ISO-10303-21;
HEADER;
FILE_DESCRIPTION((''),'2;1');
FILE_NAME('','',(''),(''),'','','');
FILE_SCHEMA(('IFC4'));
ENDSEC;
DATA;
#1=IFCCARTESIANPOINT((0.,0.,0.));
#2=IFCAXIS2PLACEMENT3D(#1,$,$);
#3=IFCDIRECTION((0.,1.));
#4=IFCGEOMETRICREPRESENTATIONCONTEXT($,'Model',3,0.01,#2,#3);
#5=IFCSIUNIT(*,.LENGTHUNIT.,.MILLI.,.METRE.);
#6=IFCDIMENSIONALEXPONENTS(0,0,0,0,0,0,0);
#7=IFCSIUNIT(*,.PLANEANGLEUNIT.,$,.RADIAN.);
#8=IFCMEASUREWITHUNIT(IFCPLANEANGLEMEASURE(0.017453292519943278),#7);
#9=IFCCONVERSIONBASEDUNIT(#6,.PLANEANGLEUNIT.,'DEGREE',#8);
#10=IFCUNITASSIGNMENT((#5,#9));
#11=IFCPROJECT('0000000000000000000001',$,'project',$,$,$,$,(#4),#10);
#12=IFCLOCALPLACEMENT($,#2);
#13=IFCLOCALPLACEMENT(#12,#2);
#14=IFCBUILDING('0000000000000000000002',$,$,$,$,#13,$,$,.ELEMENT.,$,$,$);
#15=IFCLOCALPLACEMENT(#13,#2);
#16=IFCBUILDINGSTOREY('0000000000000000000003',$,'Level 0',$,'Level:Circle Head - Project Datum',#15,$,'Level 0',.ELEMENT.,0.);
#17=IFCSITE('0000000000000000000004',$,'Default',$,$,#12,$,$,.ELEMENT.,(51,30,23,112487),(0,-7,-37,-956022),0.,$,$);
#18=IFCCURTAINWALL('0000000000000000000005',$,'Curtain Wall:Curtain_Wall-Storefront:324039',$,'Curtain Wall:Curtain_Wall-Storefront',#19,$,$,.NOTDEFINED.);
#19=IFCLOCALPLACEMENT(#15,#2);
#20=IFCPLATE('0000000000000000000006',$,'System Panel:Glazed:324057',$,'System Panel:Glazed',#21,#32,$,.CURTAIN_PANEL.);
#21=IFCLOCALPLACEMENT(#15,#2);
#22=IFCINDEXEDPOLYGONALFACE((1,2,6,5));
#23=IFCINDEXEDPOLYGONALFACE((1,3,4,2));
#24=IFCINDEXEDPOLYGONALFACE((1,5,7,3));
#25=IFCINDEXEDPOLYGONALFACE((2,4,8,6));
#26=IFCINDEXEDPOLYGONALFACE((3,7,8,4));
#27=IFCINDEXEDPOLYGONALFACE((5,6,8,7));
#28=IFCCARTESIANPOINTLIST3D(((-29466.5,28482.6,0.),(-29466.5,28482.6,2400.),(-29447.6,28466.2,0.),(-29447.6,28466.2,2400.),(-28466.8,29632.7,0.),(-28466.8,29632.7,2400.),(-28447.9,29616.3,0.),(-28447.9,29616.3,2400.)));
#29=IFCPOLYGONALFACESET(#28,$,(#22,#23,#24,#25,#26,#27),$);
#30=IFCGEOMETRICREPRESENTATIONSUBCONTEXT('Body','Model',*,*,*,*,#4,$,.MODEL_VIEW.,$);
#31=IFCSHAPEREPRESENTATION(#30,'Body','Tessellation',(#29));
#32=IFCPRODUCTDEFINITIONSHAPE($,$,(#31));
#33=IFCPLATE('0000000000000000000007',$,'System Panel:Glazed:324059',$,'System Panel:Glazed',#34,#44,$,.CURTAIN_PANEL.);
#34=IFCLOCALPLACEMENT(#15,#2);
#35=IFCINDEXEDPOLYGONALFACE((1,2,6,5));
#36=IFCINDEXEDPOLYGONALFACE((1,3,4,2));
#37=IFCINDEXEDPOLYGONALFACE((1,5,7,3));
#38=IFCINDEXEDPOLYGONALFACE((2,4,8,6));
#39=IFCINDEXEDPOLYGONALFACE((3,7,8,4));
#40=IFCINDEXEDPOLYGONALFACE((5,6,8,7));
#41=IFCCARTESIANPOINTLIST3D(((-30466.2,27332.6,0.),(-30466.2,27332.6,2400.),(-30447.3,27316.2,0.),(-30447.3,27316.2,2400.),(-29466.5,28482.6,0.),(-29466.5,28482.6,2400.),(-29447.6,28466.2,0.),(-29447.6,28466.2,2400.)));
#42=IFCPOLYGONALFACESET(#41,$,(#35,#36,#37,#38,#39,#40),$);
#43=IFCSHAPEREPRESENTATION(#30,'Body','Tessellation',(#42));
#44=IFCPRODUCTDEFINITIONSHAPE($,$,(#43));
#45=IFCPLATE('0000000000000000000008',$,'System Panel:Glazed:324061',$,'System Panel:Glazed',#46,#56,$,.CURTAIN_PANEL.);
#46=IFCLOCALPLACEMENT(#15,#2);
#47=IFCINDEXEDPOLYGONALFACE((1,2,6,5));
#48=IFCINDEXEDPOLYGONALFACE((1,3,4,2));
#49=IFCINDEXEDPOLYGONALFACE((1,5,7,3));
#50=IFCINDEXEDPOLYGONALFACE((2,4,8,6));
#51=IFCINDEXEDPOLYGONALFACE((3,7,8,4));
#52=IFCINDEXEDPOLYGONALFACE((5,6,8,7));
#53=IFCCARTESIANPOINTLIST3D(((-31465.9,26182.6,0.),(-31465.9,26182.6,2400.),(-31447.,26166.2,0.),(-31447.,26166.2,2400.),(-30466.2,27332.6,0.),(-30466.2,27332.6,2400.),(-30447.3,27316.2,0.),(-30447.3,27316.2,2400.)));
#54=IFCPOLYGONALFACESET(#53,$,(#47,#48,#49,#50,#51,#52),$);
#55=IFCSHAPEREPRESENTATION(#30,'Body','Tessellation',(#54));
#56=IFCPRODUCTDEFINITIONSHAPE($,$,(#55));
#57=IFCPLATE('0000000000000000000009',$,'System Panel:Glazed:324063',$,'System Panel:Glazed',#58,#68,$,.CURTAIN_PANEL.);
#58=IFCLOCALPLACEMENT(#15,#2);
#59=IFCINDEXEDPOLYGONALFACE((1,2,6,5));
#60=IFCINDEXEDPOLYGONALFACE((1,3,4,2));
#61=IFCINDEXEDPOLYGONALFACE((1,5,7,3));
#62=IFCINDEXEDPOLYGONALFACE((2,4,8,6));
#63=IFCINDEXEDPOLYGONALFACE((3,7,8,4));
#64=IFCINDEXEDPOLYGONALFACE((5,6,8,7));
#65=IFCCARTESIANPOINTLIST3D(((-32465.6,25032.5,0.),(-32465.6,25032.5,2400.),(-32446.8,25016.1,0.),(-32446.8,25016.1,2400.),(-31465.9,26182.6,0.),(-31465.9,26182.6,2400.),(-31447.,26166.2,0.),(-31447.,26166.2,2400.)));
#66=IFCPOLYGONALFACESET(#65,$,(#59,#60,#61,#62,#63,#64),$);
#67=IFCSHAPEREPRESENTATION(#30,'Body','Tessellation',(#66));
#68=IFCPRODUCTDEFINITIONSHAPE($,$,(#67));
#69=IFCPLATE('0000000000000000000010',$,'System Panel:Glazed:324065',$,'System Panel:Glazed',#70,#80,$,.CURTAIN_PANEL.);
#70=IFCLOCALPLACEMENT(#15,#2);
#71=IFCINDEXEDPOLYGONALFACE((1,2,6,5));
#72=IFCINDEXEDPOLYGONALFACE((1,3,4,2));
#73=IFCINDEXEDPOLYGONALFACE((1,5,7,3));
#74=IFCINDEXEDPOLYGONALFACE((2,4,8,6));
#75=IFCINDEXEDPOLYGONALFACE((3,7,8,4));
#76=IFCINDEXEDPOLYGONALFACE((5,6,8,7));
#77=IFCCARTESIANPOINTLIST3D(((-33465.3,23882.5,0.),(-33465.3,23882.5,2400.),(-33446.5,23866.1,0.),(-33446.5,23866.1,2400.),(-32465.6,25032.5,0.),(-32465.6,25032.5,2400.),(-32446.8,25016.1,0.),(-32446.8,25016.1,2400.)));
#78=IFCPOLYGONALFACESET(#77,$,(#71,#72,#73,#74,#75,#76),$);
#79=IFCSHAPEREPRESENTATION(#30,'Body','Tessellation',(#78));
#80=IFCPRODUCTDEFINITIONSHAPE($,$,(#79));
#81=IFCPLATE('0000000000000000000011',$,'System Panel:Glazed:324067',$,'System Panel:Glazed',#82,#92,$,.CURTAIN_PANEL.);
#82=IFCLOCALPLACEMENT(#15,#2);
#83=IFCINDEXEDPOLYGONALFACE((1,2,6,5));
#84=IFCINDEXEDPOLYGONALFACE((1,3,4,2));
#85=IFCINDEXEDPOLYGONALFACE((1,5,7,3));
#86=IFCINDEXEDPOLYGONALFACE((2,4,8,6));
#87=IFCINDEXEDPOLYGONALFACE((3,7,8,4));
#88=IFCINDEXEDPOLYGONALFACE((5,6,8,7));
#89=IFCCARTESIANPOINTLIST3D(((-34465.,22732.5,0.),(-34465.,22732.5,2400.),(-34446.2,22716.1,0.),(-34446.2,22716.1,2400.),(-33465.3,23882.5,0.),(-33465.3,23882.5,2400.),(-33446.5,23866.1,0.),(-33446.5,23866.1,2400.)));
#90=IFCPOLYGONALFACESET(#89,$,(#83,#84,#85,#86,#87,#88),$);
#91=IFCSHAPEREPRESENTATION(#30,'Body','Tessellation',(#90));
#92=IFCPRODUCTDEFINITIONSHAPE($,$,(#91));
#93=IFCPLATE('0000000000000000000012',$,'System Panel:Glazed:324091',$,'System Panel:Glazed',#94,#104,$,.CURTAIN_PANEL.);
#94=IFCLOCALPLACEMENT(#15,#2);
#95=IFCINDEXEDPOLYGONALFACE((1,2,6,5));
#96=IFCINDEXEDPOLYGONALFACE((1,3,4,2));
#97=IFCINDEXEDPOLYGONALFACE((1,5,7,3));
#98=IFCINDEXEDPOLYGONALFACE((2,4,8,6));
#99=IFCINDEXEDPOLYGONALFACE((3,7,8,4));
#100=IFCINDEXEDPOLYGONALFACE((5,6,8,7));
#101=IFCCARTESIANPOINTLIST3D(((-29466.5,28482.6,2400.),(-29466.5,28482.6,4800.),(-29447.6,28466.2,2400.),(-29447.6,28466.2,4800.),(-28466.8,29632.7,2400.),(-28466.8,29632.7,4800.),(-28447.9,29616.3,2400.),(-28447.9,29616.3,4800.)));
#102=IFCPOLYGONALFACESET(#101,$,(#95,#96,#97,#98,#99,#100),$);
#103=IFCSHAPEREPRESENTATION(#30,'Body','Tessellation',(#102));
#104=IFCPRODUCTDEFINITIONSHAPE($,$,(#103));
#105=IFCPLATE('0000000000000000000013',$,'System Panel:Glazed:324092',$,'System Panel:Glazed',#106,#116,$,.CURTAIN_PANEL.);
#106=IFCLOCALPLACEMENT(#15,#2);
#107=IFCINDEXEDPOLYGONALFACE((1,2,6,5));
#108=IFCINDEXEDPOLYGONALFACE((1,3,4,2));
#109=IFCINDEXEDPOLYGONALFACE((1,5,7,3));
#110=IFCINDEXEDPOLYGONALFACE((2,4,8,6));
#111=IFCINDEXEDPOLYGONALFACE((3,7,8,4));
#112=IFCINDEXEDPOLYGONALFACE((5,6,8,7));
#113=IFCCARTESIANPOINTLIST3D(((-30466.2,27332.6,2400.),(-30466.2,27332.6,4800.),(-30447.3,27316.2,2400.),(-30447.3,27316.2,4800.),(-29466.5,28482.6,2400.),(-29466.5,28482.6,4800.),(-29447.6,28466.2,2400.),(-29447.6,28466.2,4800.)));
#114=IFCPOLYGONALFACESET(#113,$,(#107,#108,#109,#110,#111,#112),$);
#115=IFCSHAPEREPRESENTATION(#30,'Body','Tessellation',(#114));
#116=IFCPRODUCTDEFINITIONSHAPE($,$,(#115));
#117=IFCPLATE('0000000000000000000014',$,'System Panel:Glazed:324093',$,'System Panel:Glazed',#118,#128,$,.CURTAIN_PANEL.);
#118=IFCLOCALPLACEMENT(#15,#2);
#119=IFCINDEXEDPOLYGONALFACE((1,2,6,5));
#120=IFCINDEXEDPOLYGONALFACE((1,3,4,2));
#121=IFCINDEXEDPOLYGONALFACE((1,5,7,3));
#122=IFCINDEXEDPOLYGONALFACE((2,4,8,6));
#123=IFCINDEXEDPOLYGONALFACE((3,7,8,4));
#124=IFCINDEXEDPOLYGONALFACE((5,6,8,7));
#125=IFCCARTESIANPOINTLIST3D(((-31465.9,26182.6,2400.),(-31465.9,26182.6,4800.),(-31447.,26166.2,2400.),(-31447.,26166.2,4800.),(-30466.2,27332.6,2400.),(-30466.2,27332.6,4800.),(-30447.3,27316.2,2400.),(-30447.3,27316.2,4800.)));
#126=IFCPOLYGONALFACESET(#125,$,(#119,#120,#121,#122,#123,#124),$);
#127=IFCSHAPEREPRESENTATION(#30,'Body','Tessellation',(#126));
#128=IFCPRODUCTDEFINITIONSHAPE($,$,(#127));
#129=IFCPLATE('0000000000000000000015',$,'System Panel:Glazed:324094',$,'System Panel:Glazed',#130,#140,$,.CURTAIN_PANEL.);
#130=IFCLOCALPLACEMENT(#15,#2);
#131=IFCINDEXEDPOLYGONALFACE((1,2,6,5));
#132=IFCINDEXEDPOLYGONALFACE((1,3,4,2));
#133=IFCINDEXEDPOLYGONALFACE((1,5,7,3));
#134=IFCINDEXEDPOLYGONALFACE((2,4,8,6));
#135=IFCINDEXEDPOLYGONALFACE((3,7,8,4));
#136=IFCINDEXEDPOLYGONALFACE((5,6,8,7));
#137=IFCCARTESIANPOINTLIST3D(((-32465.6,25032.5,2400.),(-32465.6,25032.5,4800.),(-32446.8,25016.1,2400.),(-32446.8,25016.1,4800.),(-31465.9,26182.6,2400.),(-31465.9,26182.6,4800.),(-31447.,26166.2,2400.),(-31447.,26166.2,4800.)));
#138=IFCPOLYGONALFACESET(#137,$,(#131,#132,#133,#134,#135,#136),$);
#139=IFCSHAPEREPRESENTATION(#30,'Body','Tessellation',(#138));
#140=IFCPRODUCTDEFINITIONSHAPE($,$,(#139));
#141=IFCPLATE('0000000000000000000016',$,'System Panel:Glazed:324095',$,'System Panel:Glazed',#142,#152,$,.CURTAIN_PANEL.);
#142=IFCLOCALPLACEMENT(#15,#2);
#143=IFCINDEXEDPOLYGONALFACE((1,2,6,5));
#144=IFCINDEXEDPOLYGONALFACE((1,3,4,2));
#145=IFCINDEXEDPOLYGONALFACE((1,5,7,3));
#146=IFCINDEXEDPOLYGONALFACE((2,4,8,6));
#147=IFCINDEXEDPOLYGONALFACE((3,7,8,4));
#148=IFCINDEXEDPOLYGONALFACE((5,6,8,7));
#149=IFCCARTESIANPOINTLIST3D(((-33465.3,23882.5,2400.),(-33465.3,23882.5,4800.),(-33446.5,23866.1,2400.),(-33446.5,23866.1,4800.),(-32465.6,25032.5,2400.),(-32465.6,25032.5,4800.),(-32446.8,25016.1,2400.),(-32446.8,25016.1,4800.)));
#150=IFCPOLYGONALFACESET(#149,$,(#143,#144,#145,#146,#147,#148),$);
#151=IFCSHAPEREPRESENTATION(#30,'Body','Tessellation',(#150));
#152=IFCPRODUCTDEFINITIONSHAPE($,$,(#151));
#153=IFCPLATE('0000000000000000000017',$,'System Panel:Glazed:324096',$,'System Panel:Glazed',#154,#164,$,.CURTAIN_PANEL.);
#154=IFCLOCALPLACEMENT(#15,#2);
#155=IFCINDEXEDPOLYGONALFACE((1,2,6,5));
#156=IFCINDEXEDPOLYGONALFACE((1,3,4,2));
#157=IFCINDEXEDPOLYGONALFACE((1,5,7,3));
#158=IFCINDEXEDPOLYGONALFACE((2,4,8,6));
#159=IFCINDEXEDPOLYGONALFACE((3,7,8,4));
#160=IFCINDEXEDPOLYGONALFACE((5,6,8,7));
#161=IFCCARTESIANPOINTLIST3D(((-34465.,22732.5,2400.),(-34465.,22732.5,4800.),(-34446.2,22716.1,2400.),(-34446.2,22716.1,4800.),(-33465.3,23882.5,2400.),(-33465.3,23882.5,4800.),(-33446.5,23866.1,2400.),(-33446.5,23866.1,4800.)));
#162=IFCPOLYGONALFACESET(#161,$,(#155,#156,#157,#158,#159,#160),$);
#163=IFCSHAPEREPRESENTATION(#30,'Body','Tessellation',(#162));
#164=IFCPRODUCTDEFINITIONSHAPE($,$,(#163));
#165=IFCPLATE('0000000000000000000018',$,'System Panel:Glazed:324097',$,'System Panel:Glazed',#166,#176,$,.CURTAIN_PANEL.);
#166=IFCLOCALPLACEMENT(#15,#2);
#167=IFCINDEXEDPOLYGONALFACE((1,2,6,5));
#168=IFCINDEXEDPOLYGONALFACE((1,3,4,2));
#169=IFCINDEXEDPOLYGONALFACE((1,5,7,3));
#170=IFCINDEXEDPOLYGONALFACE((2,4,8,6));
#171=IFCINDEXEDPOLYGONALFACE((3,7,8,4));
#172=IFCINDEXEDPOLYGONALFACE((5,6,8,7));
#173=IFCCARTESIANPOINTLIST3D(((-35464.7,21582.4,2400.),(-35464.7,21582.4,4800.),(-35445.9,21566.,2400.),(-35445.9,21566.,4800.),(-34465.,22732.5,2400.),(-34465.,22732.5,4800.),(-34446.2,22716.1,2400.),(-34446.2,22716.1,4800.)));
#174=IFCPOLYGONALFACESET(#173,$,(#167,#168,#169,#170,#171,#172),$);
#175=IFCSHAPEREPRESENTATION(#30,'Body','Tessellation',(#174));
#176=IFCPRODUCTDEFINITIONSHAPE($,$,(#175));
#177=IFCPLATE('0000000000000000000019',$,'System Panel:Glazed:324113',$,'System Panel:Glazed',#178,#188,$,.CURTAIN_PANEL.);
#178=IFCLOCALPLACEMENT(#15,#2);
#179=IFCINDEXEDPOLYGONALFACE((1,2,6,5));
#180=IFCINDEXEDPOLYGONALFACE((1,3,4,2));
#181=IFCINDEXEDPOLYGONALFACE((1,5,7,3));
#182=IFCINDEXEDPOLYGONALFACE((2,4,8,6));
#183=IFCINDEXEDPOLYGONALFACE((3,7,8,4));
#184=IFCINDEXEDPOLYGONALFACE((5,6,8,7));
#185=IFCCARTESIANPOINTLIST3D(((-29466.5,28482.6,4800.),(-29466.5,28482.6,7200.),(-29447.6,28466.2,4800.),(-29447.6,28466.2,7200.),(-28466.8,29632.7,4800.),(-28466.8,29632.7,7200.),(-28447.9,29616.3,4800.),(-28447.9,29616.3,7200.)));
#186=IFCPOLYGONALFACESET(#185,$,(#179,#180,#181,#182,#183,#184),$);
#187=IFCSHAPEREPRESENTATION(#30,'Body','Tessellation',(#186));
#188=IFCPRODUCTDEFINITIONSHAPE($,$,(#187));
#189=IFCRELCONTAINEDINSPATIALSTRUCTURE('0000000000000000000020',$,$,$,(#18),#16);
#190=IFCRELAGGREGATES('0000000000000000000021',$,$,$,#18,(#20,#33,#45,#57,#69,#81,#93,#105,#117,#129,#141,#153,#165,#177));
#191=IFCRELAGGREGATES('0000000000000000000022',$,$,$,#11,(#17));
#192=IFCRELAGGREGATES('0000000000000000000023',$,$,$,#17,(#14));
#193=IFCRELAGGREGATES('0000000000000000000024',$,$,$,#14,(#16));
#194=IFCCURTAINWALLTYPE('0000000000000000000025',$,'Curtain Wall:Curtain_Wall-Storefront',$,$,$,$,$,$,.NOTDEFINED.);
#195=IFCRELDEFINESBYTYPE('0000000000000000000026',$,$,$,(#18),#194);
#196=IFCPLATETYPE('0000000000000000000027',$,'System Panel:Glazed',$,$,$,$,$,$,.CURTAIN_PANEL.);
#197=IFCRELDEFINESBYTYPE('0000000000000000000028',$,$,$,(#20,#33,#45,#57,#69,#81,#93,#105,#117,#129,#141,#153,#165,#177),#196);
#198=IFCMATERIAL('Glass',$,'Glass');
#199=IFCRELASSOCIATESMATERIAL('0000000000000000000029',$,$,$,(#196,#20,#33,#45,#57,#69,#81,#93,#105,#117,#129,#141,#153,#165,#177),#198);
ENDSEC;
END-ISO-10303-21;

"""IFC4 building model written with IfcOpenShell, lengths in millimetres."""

from ifc_helpers import new_model, entity, si_unit, converted_unit, direction, frame, origin, place, context, subcontext, project, spatial, indexed_curve, outline, extrude, source, transform, mapped, material, type_object, type_shapes, element, aggregate, save


model = new_model("IFC4")

# Units and contexts
model_context = context("Model", 3, precision=0.01, world=origin(), true_north=direction((0.0, 1.0)))
body_context = subcontext(model_context, "Body", "Model", "MODEL_VIEW")
ifc_project = project(units=[si_unit("LENGTHUNIT", "METRE", prefix="MILLI"), converted_unit("PLANEANGLEUNIT", "DEGREE", entity("IfcPlaneAngleMeasure", 0.017453292519943278), si_unit("PLANEANGLEUNIT", "RADIAN"), dimensions=[0, 0, 0, 0, 0, 0, 0])], contexts=[model_context])

# Site, building, storey
site_placement = place(None, origin())
site = spatial("IfcSite", under=ifc_project, at=site_placement, Name="Default", CompositionType="ELEMENT", RefLatitude=(51, 30, 23, 112487), RefLongitude=(0, -7, -37, -956022), RefElevation=0.0)
building_placement = place(site_placement, origin())
building = spatial("IfcBuilding", under=site, at=building_placement, CompositionType="ELEMENT")
storey_placement = place(building_placement, origin())
storey = spatial("IfcBuildingStorey", under=building, at=storey_placement, Name="Level 0", ObjectType="Level:Circle Head - Project Datum", LongName="Level 0", CompositionType="ELEMENT", Elevation=0.0)

# Curtain wall, plates
curtain_wall_type = type_object("IfcCurtainWallType", Name="Curtain Wall:Curtain_Wall-Storefront", PredefinedType="NOTDEFINED")
curtain_wall_placement = place(storey_placement, origin())
curtain_wall = element("IfcCurtainWall", 1, at=curtain_wall_placement, inside=storey, type_object=curtain_wall_type, Name="Curtain Wall:Curtain_Wall-Storefront:324039", ObjectType="Curtain Wall:Curtain_Wall-Storefront", PredefinedType="NOTDEFINED")
ifc_material = material(Name="Glass", Category="Glass")
plate_type_1 = type_object("IfcPlateType", Name="System Panel:Glazed", PredefinedType="CURTAIN_PANEL", material=ifc_material)
shared_shape_1 = source(origin(), body_context, "Body", "SweptSolid", [
    extrude(outline(indexed_curve([(-12.5, -761.9), (12.5, -761.9), (12.5, 761.9), (-12.5, 761.9), (-12.5, -761.9)], self_intersect=False)), frame((0.0, 37.0, 0.0), z_axis=(0.0, 0.0, 1.0), x_axis=(0.0, 1.0, 0.0)), (0.0, 0.0, 1.0), 2400.0),
])
type_shapes(plate_type_1, [shared_shape_1])
plate_1_placement = place(curtain_wall_placement, frame((-28985.1, 29073.7, 0.0), z_axis=(0.0, 0.0, 1.0), x_axis=(-0.656059, -0.75471, 0.0)))
plate_1 = element("IfcPlate", 2, at=plate_1_placement, type_object=plate_type_1, material=ifc_material, Name="System Panel:Glazed:324057", ObjectType="System Panel:Glazed", PredefinedType="CURTAIN_PANEL", context=body_context, shape_type="MappedRepresentation", body=[
    mapped(shared_shape_1, transform((0.0, 0.0, 0.0), scale=1.0)),
])
plate_2_placement = place(curtain_wall_placement, frame((-29984.8, 27923.7, 0.0), z_axis=(0.0, 0.0, 1.0), x_axis=(-0.656059, -0.75471, 0.0)))
plate_2 = element("IfcPlate", 3, at=plate_2_placement, type_object=plate_type_1, material=ifc_material, Name="System Panel:Glazed:324059", ObjectType="System Panel:Glazed", PredefinedType="CURTAIN_PANEL", context=body_context, shape_type="MappedRepresentation", body=[
    mapped(shared_shape_1, transform((0.0, 0.0, 0.0), scale=1.0)),
])
plate_3_placement = place(curtain_wall_placement, frame((-30984.5, 26773.7, 0.0), z_axis=(0.0, 0.0, 1.0), x_axis=(-0.656059, -0.75471, 0.0)))
plate_3 = element("IfcPlate", 4, at=plate_3_placement, type_object=plate_type_1, material=ifc_material, Name="System Panel:Glazed:324061", ObjectType="System Panel:Glazed", PredefinedType="CURTAIN_PANEL", context=body_context, shape_type="MappedRepresentation", body=[
    mapped(shared_shape_1, transform((0.0, 0.0, 0.0), scale=1.0)),
])
plate_4_placement = place(curtain_wall_placement, frame((-31984.3, 25623.6, 0.0), z_axis=(0.0, 0.0, 1.0), x_axis=(-0.656059, -0.75471, 0.0)))
plate_4 = element("IfcPlate", 5, at=plate_4_placement, type_object=plate_type_1, material=ifc_material, Name="System Panel:Glazed:324063", ObjectType="System Panel:Glazed", PredefinedType="CURTAIN_PANEL", context=body_context, shape_type="MappedRepresentation", body=[
    mapped(shared_shape_1, transform((0.0, 0.0, 0.0), scale=1.0)),
])
plate_5_placement = place(curtain_wall_placement, frame((-32984.0, 24473.6, 0.0), z_axis=(0.0, 0.0, 1.0), x_axis=(-0.656059, -0.75471, 0.0)))
plate_5 = element("IfcPlate", 6, at=plate_5_placement, type_object=plate_type_1, material=ifc_material, Name="System Panel:Glazed:324065", ObjectType="System Panel:Glazed", PredefinedType="CURTAIN_PANEL", context=body_context, shape_type="MappedRepresentation", body=[
    mapped(shared_shape_1, transform((0.0, 0.0, 0.0), scale=1.0)),
])
plate_6_placement = place(curtain_wall_placement, frame((-33983.7, 23323.6, 0.0), z_axis=(0.0, 0.0, 1.0), x_axis=(-0.656059, -0.75471, 0.0)))
plate_6 = element("IfcPlate", 7, at=plate_6_placement, type_object=plate_type_1, material=ifc_material, Name="System Panel:Glazed:324067", ObjectType="System Panel:Glazed", PredefinedType="CURTAIN_PANEL", context=body_context, shape_type="MappedRepresentation", body=[
    mapped(shared_shape_1, transform((0.0, 0.0, 0.0), scale=1.0)),
])
plate_7_placement = place(curtain_wall_placement, frame((-28985.1, 29073.7, 2400.0), z_axis=(0.0, 0.0, 1.0), x_axis=(-0.656059, -0.75471, 0.0)))
plate_7 = element("IfcPlate", 8, at=plate_7_placement, type_object=plate_type_1, material=ifc_material, Name="System Panel:Glazed:324091", ObjectType="System Panel:Glazed", PredefinedType="CURTAIN_PANEL", context=body_context, shape_type="MappedRepresentation", body=[
    mapped(shared_shape_1, transform((0.0, 0.0, 0.0), scale=1.0)),
])
plate_8_placement = place(curtain_wall_placement, frame((-29984.8, 27923.7, 2400.0), z_axis=(0.0, 0.0, 1.0), x_axis=(-0.656059, -0.75471, 0.0)))
plate_8 = element("IfcPlate", 9, at=plate_8_placement, type_object=plate_type_1, material=ifc_material, Name="System Panel:Glazed:324092", ObjectType="System Panel:Glazed", PredefinedType="CURTAIN_PANEL", context=body_context, shape_type="MappedRepresentation", body=[
    mapped(shared_shape_1, transform((0.0, 0.0, 0.0), scale=1.0)),
])
plate_9_placement = place(curtain_wall_placement, frame((-30984.5, 26773.7, 2400.0), z_axis=(0.0, 0.0, 1.0), x_axis=(-0.656059, -0.75471, 0.0)))
plate_9 = element("IfcPlate", 10, at=plate_9_placement, type_object=plate_type_1, material=ifc_material, Name="System Panel:Glazed:324093", ObjectType="System Panel:Glazed", PredefinedType="CURTAIN_PANEL", context=body_context, shape_type="MappedRepresentation", body=[
    mapped(shared_shape_1, transform((0.0, 0.0, 0.0), scale=1.0)),
])
plate_10_placement = place(curtain_wall_placement, frame((-31984.3, 25623.6, 2400.0), z_axis=(0.0, 0.0, 1.0), x_axis=(-0.656059, -0.75471, 0.0)))
plate_10 = element("IfcPlate", 11, at=plate_10_placement, type_object=plate_type_1, material=ifc_material, Name="System Panel:Glazed:324094", ObjectType="System Panel:Glazed", PredefinedType="CURTAIN_PANEL", context=body_context, shape_type="MappedRepresentation", body=[
    mapped(shared_shape_1, transform((0.0, 0.0, 0.0), scale=1.0)),
])
plate_11_placement = place(curtain_wall_placement, frame((-32984.0, 24473.6, 2400.0), z_axis=(0.0, 0.0, 1.0), x_axis=(-0.656059, -0.75471, 0.0)))
plate_11 = element("IfcPlate", 12, at=plate_11_placement, type_object=plate_type_1, material=ifc_material, Name="System Panel:Glazed:324095", ObjectType="System Panel:Glazed", PredefinedType="CURTAIN_PANEL", context=body_context, shape_type="MappedRepresentation", body=[
    mapped(shared_shape_1, transform((0.0, 0.0, 0.0), scale=1.0)),
])
plate_12_placement = place(curtain_wall_placement, frame((-33983.7, 23323.6, 2400.0), z_axis=(0.0, 0.0, 1.0), x_axis=(-0.656059, -0.75471, 0.0)))
plate_12 = element("IfcPlate", 13, at=plate_12_placement, type_object=plate_type_1, material=ifc_material, Name="System Panel:Glazed:324096", ObjectType="System Panel:Glazed", PredefinedType="CURTAIN_PANEL", context=body_context, shape_type="MappedRepresentation", body=[
    mapped(shared_shape_1, transform((0.0, 0.0, 0.0), scale=1.0)),
])
plate_13_placement = place(curtain_wall_placement, frame((-34983.4, 22173.5, 2400.0), z_axis=(0.0, 0.0, 1.0), x_axis=(-0.656059, -0.75471, 0.0)))
plate_13 = element("IfcPlate", 14, at=plate_13_placement, type_object=plate_type_1, material=ifc_material, Name="System Panel:Glazed:324097", ObjectType="System Panel:Glazed", PredefinedType="CURTAIN_PANEL", context=body_context, shape_type="MappedRepresentation", body=[
    mapped(shared_shape_1, transform((0.0, 0.0, 0.0), scale=1.0)),
])
plate_14_placement = place(curtain_wall_placement, frame((-28985.1, 29073.7, 4800.0), z_axis=(0.0, 0.0, 1.0), x_axis=(-0.656059, -0.75471, 0.0)))
plate_14 = element("IfcPlate", 15, at=plate_14_placement, type_object=plate_type_1, material=ifc_material, Name="System Panel:Glazed:324113", ObjectType="System Panel:Glazed", PredefinedType="CURTAIN_PANEL", context=body_context, shape_type="MappedRepresentation", body=[
    mapped(shared_shape_1, transform((0.0, 0.0, 0.0), scale=1.0)),
])
aggregate(curtain_wall, [plate_1, plate_2, plate_3, plate_4, plate_5, plate_6, plate_7, plate_8, plate_9, plate_10, plate_11, plate_12, plate_13, plate_14])

save(model, "model.ifc")
